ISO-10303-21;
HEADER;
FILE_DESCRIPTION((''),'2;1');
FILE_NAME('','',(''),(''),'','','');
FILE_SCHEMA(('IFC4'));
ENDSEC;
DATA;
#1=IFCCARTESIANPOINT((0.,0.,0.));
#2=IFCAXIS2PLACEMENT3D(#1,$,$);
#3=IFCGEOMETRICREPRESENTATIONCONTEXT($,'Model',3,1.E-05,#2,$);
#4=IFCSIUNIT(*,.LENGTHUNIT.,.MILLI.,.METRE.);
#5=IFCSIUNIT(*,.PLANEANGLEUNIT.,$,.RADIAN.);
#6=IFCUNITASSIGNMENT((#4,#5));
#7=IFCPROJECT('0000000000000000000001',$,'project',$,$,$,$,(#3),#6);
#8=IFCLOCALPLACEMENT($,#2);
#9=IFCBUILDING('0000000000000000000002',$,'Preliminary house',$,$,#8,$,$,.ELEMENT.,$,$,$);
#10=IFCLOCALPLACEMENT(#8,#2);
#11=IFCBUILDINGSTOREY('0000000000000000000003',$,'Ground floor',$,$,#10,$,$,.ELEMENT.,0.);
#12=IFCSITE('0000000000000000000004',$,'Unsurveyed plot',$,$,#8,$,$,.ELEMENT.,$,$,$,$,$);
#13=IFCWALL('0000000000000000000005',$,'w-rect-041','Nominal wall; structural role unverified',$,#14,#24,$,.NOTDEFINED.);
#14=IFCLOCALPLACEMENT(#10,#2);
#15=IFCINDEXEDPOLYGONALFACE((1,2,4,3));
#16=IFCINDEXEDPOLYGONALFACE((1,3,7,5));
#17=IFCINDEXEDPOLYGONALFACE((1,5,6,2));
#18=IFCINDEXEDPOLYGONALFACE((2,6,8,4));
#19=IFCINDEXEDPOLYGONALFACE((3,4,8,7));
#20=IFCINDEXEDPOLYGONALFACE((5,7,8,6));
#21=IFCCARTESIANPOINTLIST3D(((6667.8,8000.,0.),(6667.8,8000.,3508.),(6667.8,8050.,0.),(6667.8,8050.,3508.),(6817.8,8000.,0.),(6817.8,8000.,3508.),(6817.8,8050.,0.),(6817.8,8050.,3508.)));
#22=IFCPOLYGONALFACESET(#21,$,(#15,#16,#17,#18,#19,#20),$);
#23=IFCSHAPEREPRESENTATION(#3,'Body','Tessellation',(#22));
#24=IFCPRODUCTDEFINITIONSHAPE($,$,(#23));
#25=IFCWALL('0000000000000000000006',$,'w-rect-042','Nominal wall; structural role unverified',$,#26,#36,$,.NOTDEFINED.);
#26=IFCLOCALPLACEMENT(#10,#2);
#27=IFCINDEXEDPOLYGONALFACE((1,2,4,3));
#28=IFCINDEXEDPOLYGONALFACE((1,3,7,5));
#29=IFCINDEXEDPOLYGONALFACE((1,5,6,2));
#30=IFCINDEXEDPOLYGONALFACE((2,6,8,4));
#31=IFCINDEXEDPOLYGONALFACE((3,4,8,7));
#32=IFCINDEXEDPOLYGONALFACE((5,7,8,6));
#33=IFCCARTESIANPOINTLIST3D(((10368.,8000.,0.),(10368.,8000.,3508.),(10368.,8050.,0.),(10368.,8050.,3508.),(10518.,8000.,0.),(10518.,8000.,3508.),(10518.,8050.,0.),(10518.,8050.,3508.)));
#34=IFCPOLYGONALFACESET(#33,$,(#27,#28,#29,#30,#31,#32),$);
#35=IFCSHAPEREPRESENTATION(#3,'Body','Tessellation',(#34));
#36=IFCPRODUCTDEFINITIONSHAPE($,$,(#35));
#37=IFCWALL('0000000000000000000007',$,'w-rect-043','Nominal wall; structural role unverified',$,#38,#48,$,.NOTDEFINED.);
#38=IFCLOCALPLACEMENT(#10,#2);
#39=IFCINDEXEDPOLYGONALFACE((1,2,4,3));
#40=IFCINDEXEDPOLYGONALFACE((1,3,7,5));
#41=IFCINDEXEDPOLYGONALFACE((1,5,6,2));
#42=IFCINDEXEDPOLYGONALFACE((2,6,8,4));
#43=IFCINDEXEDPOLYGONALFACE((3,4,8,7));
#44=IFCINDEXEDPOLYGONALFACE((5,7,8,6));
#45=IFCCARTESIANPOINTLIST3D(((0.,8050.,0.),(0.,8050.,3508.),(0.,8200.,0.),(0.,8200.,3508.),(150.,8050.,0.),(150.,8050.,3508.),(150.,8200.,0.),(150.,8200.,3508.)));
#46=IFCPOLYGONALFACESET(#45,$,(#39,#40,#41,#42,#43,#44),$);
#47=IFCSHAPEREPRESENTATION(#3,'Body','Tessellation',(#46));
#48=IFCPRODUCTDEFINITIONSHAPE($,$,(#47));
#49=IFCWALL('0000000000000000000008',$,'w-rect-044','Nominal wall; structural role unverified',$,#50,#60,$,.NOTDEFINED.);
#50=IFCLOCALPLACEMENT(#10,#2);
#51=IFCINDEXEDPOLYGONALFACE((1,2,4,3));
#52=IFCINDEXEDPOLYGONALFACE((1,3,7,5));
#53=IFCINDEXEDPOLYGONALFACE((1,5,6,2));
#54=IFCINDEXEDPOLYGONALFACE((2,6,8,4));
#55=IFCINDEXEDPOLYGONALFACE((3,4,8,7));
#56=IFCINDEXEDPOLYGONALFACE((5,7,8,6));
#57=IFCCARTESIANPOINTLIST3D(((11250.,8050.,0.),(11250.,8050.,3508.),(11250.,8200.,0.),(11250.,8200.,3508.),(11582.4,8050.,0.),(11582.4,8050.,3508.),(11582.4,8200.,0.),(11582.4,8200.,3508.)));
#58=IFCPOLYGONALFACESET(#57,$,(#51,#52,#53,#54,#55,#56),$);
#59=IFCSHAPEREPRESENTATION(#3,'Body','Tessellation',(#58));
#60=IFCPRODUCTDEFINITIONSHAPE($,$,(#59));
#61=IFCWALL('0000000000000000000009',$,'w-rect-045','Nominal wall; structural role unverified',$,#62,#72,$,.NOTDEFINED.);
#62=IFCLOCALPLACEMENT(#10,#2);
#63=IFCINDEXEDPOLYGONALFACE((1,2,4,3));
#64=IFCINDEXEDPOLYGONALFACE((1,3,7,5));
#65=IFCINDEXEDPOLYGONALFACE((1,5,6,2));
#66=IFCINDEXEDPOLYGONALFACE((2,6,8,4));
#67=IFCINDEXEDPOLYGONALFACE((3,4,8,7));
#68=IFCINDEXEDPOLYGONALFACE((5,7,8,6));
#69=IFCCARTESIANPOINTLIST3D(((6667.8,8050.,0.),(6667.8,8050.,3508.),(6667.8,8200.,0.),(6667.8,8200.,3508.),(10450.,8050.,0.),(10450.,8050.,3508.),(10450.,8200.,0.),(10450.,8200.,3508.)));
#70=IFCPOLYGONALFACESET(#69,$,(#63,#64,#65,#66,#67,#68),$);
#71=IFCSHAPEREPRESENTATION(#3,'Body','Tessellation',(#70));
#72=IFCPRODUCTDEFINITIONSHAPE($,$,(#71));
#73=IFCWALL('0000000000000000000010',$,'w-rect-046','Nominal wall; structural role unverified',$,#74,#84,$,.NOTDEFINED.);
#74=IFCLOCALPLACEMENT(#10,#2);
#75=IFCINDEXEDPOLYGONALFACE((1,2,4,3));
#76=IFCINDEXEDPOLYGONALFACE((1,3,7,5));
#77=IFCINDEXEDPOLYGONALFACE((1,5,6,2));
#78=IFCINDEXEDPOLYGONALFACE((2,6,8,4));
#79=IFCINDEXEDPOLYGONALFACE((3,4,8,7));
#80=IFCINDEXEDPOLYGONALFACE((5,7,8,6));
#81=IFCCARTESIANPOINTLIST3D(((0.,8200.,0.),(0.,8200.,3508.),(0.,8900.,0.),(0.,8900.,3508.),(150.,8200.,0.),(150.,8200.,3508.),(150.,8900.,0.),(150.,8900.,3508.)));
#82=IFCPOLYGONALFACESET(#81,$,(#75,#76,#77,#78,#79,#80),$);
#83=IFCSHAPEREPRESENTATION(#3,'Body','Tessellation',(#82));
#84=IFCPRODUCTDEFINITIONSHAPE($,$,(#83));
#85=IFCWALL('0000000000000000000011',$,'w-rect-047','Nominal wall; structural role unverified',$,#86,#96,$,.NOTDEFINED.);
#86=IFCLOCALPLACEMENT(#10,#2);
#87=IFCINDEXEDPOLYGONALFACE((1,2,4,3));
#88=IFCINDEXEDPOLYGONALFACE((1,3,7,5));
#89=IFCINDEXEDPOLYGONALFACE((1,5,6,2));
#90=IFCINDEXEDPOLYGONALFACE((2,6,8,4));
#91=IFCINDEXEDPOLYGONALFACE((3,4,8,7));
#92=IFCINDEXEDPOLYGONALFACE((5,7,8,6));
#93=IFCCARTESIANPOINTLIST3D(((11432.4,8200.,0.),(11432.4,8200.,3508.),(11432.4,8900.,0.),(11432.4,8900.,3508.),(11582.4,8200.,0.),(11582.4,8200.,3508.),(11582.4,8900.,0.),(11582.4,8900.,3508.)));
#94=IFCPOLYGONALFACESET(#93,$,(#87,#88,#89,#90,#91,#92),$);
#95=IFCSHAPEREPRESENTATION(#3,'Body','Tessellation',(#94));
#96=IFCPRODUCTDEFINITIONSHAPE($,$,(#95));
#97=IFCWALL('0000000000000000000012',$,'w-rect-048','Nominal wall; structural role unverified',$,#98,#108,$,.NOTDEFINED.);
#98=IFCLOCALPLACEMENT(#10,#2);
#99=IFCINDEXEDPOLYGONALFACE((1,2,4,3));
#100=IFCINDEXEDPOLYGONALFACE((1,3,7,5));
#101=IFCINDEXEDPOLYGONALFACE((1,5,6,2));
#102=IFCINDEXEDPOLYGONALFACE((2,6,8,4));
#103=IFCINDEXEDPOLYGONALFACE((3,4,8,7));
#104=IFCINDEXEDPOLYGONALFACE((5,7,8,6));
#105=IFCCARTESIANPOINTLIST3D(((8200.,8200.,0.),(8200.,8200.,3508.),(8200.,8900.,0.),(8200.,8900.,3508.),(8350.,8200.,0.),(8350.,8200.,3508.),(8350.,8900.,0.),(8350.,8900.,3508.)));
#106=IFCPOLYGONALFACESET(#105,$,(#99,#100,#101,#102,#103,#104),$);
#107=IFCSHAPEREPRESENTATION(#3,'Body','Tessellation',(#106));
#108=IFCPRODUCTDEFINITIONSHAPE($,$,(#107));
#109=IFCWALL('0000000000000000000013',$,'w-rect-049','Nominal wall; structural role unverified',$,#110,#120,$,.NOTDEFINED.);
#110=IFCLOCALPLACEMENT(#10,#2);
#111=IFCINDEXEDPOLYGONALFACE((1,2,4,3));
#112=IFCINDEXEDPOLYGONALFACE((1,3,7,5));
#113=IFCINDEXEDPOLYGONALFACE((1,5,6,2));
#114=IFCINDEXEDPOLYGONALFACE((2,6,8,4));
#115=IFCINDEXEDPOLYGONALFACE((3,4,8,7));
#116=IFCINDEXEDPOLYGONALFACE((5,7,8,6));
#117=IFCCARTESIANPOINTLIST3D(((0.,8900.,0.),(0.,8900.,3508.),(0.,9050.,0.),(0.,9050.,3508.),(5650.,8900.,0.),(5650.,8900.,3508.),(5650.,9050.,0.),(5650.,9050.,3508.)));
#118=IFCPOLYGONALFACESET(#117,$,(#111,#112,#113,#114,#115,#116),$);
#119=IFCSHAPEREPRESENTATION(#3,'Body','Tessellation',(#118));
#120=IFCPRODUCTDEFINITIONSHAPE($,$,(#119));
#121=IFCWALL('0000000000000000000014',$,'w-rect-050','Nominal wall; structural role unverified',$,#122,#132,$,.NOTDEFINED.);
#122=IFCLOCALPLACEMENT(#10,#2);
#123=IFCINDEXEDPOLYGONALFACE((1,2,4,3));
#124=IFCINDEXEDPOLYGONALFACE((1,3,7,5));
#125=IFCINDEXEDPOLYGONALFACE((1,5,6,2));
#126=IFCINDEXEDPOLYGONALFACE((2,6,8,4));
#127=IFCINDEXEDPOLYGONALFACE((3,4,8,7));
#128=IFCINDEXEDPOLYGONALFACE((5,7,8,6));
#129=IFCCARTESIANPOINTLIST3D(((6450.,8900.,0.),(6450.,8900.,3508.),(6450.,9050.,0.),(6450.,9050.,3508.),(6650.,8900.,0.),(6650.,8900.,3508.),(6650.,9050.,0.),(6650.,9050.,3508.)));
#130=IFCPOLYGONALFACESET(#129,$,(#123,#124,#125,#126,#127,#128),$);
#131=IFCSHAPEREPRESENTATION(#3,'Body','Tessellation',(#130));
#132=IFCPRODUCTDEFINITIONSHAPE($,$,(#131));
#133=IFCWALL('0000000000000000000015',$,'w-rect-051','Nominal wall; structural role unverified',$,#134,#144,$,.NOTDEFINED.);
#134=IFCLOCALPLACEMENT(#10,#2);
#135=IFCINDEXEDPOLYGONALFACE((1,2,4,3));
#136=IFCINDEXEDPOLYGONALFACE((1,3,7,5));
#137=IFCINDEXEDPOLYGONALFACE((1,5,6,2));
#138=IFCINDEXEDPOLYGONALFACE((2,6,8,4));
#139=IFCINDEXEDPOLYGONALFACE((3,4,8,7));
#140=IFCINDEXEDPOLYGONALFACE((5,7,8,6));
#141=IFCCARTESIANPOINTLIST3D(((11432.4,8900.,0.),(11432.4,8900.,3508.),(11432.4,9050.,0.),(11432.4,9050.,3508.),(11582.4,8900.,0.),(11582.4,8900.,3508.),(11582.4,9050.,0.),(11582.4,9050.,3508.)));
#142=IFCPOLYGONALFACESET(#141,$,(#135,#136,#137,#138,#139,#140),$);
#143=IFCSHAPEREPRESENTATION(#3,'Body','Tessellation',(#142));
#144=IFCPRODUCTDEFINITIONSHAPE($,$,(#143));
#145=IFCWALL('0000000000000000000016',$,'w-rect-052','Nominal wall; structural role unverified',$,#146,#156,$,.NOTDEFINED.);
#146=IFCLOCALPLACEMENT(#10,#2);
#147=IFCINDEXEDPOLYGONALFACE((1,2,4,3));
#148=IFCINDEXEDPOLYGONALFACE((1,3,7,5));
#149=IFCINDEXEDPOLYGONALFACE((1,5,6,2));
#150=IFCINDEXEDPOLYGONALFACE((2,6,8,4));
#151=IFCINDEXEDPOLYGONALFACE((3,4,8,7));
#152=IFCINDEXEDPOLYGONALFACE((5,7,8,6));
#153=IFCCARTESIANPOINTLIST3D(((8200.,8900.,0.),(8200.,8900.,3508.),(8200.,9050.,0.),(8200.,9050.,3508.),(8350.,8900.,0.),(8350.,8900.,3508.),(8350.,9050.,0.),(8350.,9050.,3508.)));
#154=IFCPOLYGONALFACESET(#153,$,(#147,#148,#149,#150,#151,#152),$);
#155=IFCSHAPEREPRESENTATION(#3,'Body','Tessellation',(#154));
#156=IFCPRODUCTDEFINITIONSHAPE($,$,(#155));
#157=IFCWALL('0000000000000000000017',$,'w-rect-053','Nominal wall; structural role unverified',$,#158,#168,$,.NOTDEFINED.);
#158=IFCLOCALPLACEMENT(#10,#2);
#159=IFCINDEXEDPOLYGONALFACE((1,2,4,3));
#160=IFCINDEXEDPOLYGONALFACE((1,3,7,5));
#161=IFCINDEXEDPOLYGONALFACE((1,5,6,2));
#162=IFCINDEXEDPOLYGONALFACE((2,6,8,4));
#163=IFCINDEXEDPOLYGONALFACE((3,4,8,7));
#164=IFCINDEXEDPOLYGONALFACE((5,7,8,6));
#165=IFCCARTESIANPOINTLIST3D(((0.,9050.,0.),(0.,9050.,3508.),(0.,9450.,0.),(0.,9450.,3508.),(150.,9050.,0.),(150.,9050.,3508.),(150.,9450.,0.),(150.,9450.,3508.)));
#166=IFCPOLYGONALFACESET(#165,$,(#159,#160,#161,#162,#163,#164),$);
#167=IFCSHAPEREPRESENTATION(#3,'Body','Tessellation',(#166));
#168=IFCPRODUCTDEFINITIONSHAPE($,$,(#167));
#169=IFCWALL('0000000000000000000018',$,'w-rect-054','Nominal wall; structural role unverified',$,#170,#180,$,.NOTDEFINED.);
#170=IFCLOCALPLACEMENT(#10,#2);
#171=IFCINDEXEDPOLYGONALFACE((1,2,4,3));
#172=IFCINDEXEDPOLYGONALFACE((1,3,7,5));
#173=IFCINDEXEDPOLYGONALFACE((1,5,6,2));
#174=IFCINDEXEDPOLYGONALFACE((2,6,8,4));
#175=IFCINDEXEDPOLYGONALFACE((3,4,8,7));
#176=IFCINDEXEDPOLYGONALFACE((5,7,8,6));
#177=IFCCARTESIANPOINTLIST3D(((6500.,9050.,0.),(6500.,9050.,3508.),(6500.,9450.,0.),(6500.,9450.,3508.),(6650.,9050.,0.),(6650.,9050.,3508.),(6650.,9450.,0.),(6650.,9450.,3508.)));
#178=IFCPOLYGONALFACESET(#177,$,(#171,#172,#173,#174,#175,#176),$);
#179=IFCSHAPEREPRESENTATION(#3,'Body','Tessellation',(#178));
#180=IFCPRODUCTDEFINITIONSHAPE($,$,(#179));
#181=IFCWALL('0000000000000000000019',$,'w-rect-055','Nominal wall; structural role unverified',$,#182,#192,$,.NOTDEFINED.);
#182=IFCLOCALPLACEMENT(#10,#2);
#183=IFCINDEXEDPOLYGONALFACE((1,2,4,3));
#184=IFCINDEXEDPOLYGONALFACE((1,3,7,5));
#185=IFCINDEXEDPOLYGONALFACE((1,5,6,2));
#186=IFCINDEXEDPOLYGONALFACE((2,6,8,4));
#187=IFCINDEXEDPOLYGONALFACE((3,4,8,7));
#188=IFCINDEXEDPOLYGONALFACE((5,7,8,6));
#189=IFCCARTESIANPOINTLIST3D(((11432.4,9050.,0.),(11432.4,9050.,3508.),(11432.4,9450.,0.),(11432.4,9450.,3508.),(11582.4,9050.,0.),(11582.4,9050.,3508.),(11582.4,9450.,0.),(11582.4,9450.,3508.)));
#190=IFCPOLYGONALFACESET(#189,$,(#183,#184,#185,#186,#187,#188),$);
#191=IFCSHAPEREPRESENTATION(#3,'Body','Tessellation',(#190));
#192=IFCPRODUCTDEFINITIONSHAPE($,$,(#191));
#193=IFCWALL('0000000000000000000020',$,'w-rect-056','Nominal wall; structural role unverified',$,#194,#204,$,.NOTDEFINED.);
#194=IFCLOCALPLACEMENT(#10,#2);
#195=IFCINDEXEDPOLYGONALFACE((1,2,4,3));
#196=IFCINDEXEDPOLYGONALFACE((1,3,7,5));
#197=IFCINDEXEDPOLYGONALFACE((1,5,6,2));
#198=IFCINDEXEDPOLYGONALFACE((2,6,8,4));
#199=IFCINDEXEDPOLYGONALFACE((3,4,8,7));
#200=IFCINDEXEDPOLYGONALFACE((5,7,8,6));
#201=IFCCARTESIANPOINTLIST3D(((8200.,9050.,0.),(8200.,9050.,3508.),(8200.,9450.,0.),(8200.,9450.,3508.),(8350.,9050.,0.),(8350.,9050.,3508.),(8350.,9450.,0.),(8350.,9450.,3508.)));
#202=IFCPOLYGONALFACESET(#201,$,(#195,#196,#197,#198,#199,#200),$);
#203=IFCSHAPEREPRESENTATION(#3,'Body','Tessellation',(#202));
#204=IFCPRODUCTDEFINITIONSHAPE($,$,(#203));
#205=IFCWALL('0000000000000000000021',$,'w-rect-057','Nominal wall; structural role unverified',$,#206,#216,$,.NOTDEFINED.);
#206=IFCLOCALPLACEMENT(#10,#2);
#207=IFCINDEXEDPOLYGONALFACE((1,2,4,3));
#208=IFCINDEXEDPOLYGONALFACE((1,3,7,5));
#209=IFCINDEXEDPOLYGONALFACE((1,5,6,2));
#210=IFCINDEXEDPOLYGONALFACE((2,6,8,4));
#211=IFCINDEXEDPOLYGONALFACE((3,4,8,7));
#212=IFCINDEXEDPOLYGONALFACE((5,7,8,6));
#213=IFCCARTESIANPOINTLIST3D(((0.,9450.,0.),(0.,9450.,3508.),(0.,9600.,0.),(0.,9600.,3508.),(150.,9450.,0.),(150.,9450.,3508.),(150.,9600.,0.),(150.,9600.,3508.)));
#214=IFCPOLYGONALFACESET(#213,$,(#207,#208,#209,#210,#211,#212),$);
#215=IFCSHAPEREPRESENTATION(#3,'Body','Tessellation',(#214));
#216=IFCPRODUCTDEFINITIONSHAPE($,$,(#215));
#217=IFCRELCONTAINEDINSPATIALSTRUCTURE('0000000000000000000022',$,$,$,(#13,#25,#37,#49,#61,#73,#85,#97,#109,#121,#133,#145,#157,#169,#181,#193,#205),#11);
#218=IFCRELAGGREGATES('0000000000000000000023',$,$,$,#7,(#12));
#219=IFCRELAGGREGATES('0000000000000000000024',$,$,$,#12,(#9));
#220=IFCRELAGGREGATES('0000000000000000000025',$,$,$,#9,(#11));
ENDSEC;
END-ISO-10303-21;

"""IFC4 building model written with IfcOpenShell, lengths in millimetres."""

from ifc_helpers import new_model, si_unit, origin, place, context, project, spatial, polyline, outline, extrude, element, save


model = new_model("IFC4")

# Units and contexts
model_context = context("Model", 3, precision=1e-05, world=origin())
ifc_project = project(units=[si_unit("LENGTHUNIT", "METRE", prefix="MILLI"), si_unit("PLANEANGLEUNIT", "RADIAN")], contexts=[model_context])

# Site, building, storey
placement_1 = place(None, origin())
site = spatial("IfcSite", under=ifc_project, at=placement_1, Name="Unsurveyed plot", CompositionType="ELEMENT")
building = spatial("IfcBuilding", under=site, at=placement_1, Name="Preliminary house", CompositionType="ELEMENT")
placement_2 = place(placement_1, origin())
storey = spatial("IfcBuildingStorey", under=building, at=placement_2, Name="Ground floor", CompositionType="ELEMENT", Elevation=0.0)

# Walls
element("IfcWall", 1, at=placement_2, inside=storey, Name="w-rect-041", Description="Nominal wall; structural role unverified", PredefinedType="NOTDEFINED", context=model_context, shape_type="SweptSolid", body=[
    extrude(outline(polyline([(6667.8, 8000.0), (6817.8, 8000.0), (6817.8, 8050.0), (6667.8, 8050.0), (6667.8, 8000.0)])), origin(), (0.0, 0.0, 1.0), 3508.0),
])
element("IfcWall", 2, at=placement_2, inside=storey, Name="w-rect-042", Description="Nominal wall; structural role unverified", PredefinedType="NOTDEFINED", context=model_context, shape_type="SweptSolid", body=[
    extrude(outline(polyline([(10368.0, 8000.0), (10518.0, 8000.0), (10518.0, 8050.0), (10368.0, 8050.0), (10368.0, 8000.0)])), origin(), (0.0, 0.0, 1.0), 3508.0),
])
element("IfcWall", 3, at=placement_2, inside=storey, Name="w-rect-043", Description="Nominal wall; structural role unverified", PredefinedType="NOTDEFINED", context=model_context, shape_type="SweptSolid", body=[
    extrude(outline(polyline([(0.0, 8050.0), (150.0, 8050.0), (150.0, 8200.0), (0.0, 8200.0), (0.0, 8050.0)])), origin(), (0.0, 0.0, 1.0), 3508.0),
])
element("IfcWall", 4, at=placement_2, inside=storey, Name="w-rect-044", Description="Nominal wall; structural role unverified", PredefinedType="NOTDEFINED", context=model_context, shape_type="SweptSolid", body=[
    extrude(outline(polyline([(11250.0, 8050.0), (11582.4, 8050.0), (11582.4, 8200.0), (11250.0, 8200.0), (11250.0, 8050.0)])), origin(), (0.0, 0.0, 1.0), 3508.0),
])
element("IfcWall", 5, at=placement_2, inside=storey, Name="w-rect-045", Description="Nominal wall; structural role unverified", PredefinedType="NOTDEFINED", context=model_context, shape_type="SweptSolid", body=[
    extrude(outline(polyline([(6667.8, 8050.0), (10450.0, 8050.0), (10450.0, 8200.0), (6667.8, 8200.0), (6667.8, 8050.0)])), origin(), (0.0, 0.0, 1.0), 3508.0),
])
element("IfcWall", 6, at=placement_2, inside=storey, Name="w-rect-046", Description="Nominal wall; structural role unverified", PredefinedType="NOTDEFINED", context=model_context, shape_type="SweptSolid", body=[
    extrude(outline(polyline([(0.0, 8200.0), (150.0, 8200.0), (150.0, 8900.0), (0.0, 8900.0), (0.0, 8200.0)])), origin(), (0.0, 0.0, 1.0), 3508.0),
])
element("IfcWall", 7, at=placement_2, inside=storey, Name="w-rect-047", Description="Nominal wall; structural role unverified", PredefinedType="NOTDEFINED", context=model_context, shape_type="SweptSolid", body=[
    extrude(outline(polyline([(11432.4, 8200.0), (11582.4, 8200.0), (11582.4, 8900.0), (11432.4, 8900.0), (11432.4, 8200.0)])), origin(), (0.0, 0.0, 1.0), 3508.0),
])
element("IfcWall", 8, at=placement_2, inside=storey, Name="w-rect-048", Description="Nominal wall; structural role unverified", PredefinedType="NOTDEFINED", context=model_context, shape_type="SweptSolid", body=[
    extrude(outline(polyline([(8200.0, 8200.0), (8350.0, 8200.0), (8350.0, 8900.0), (8200.0, 8900.0), (8200.0, 8200.0)])), origin(), (0.0, 0.0, 1.0), 3508.0),
])
element("IfcWall", 9, at=placement_2, inside=storey, Name="w-rect-049", Description="Nominal wall; structural role unverified", PredefinedType="NOTDEFINED", context=model_context, shape_type="SweptSolid", body=[
    extrude(outline(polyline([(0.0, 8900.0), (5650.0, 8900.0), (5650.0, 9050.0), (0.0, 9050.0), (0.0, 8900.0)])), origin(), (0.0, 0.0, 1.0), 3508.0),
])
element("IfcWall", 10, at=placement_2, inside=storey, Name="w-rect-050", Description="Nominal wall; structural role unverified", PredefinedType="NOTDEFINED", context=model_context, shape_type="SweptSolid", body=[
    extrude(outline(polyline([(6450.0, 8900.0), (6650.0, 8900.0), (6650.0, 9050.0), (6450.0, 9050.0), (6450.0, 8900.0)])), origin(), (0.0, 0.0, 1.0), 3508.0),
])
element("IfcWall", 11, at=placement_2, inside=storey, Name="w-rect-051", Description="Nominal wall; structural role unverified", PredefinedType="NOTDEFINED", context=model_context, shape_type="SweptSolid", body=[
    extrude(outline(polyline([(11432.4, 8900.0), (11582.4, 8900.0), (11582.4, 9050.0), (11432.4, 9050.0), (11432.4, 8900.0)])), origin(), (0.0, 0.0, 1.0), 3508.0),
])
element("IfcWall", 12, at=placement_2, inside=storey, Name="w-rect-052", Description="Nominal wall; structural role unverified", PredefinedType="NOTDEFINED", context=model_context, shape_type="SweptSolid", body=[
    extrude(outline(polyline([(8200.0, 8900.0), (8350.0, 8900.0), (8350.0, 9050.0), (8200.0, 9050.0), (8200.0, 8900.0)])), origin(), (0.0, 0.0, 1.0), 3508.0),
])
element("IfcWall", 13, at=placement_2, inside=storey, Name="w-rect-053", Description="Nominal wall; structural role unverified", PredefinedType="NOTDEFINED", context=model_context, shape_type="SweptSolid", body=[
    extrude(outline(polyline([(0.0, 9050.0), (150.0, 9050.0), (150.0, 9450.0), (0.0, 9450.0), (0.0, 9050.0)])), origin(), (0.0, 0.0, 1.0), 3508.0),
])
element("IfcWall", 14, at=placement_2, inside=storey, Name="w-rect-054", Description="Nominal wall; structural role unverified", PredefinedType="NOTDEFINED", context=model_context, shape_type="SweptSolid", body=[
    extrude(outline(polyline([(6500.0, 9050.0), (6650.0, 9050.0), (6650.0, 9450.0), (6500.0, 9450.0), (6500.0, 9050.0)])), origin(), (0.0, 0.0, 1.0), 3508.0),
])
element("IfcWall", 15, at=placement_2, inside=storey, Name="w-rect-055", Description="Nominal wall; structural role unverified", PredefinedType="NOTDEFINED", context=model_context, shape_type="SweptSolid", body=[
    extrude(outline(polyline([(11432.4, 9050.0), (11582.4, 9050.0), (11582.4, 9450.0), (11432.4, 9450.0), (11432.4, 9050.0)])), origin(), (0.0, 0.0, 1.0), 3508.0),
])
element("IfcWall", 16, at=placement_2, inside=storey, Name="w-rect-056", Description="Nominal wall; structural role unverified", PredefinedType="NOTDEFINED", context=model_context, shape_type="SweptSolid", body=[
    extrude(outline(polyline([(8200.0, 9050.0), (8350.0, 9050.0), (8350.0, 9450.0), (8200.0, 9450.0), (8200.0, 9050.0)])), origin(), (0.0, 0.0, 1.0), 3508.0),
])
element("IfcWall", 17, at=placement_2, inside=storey, Name="w-rect-057", Description="Nominal wall; structural role unverified", PredefinedType="NOTDEFINED", context=model_context, shape_type="SweptSolid", body=[
    extrude(outline(polyline([(0.0, 9450.0), (150.0, 9450.0), (150.0, 9600.0), (0.0, 9600.0), (0.0, 9450.0)])), origin(), (0.0, 0.0, 1.0), 3508.0),
])

save(model, "model.ifc")
